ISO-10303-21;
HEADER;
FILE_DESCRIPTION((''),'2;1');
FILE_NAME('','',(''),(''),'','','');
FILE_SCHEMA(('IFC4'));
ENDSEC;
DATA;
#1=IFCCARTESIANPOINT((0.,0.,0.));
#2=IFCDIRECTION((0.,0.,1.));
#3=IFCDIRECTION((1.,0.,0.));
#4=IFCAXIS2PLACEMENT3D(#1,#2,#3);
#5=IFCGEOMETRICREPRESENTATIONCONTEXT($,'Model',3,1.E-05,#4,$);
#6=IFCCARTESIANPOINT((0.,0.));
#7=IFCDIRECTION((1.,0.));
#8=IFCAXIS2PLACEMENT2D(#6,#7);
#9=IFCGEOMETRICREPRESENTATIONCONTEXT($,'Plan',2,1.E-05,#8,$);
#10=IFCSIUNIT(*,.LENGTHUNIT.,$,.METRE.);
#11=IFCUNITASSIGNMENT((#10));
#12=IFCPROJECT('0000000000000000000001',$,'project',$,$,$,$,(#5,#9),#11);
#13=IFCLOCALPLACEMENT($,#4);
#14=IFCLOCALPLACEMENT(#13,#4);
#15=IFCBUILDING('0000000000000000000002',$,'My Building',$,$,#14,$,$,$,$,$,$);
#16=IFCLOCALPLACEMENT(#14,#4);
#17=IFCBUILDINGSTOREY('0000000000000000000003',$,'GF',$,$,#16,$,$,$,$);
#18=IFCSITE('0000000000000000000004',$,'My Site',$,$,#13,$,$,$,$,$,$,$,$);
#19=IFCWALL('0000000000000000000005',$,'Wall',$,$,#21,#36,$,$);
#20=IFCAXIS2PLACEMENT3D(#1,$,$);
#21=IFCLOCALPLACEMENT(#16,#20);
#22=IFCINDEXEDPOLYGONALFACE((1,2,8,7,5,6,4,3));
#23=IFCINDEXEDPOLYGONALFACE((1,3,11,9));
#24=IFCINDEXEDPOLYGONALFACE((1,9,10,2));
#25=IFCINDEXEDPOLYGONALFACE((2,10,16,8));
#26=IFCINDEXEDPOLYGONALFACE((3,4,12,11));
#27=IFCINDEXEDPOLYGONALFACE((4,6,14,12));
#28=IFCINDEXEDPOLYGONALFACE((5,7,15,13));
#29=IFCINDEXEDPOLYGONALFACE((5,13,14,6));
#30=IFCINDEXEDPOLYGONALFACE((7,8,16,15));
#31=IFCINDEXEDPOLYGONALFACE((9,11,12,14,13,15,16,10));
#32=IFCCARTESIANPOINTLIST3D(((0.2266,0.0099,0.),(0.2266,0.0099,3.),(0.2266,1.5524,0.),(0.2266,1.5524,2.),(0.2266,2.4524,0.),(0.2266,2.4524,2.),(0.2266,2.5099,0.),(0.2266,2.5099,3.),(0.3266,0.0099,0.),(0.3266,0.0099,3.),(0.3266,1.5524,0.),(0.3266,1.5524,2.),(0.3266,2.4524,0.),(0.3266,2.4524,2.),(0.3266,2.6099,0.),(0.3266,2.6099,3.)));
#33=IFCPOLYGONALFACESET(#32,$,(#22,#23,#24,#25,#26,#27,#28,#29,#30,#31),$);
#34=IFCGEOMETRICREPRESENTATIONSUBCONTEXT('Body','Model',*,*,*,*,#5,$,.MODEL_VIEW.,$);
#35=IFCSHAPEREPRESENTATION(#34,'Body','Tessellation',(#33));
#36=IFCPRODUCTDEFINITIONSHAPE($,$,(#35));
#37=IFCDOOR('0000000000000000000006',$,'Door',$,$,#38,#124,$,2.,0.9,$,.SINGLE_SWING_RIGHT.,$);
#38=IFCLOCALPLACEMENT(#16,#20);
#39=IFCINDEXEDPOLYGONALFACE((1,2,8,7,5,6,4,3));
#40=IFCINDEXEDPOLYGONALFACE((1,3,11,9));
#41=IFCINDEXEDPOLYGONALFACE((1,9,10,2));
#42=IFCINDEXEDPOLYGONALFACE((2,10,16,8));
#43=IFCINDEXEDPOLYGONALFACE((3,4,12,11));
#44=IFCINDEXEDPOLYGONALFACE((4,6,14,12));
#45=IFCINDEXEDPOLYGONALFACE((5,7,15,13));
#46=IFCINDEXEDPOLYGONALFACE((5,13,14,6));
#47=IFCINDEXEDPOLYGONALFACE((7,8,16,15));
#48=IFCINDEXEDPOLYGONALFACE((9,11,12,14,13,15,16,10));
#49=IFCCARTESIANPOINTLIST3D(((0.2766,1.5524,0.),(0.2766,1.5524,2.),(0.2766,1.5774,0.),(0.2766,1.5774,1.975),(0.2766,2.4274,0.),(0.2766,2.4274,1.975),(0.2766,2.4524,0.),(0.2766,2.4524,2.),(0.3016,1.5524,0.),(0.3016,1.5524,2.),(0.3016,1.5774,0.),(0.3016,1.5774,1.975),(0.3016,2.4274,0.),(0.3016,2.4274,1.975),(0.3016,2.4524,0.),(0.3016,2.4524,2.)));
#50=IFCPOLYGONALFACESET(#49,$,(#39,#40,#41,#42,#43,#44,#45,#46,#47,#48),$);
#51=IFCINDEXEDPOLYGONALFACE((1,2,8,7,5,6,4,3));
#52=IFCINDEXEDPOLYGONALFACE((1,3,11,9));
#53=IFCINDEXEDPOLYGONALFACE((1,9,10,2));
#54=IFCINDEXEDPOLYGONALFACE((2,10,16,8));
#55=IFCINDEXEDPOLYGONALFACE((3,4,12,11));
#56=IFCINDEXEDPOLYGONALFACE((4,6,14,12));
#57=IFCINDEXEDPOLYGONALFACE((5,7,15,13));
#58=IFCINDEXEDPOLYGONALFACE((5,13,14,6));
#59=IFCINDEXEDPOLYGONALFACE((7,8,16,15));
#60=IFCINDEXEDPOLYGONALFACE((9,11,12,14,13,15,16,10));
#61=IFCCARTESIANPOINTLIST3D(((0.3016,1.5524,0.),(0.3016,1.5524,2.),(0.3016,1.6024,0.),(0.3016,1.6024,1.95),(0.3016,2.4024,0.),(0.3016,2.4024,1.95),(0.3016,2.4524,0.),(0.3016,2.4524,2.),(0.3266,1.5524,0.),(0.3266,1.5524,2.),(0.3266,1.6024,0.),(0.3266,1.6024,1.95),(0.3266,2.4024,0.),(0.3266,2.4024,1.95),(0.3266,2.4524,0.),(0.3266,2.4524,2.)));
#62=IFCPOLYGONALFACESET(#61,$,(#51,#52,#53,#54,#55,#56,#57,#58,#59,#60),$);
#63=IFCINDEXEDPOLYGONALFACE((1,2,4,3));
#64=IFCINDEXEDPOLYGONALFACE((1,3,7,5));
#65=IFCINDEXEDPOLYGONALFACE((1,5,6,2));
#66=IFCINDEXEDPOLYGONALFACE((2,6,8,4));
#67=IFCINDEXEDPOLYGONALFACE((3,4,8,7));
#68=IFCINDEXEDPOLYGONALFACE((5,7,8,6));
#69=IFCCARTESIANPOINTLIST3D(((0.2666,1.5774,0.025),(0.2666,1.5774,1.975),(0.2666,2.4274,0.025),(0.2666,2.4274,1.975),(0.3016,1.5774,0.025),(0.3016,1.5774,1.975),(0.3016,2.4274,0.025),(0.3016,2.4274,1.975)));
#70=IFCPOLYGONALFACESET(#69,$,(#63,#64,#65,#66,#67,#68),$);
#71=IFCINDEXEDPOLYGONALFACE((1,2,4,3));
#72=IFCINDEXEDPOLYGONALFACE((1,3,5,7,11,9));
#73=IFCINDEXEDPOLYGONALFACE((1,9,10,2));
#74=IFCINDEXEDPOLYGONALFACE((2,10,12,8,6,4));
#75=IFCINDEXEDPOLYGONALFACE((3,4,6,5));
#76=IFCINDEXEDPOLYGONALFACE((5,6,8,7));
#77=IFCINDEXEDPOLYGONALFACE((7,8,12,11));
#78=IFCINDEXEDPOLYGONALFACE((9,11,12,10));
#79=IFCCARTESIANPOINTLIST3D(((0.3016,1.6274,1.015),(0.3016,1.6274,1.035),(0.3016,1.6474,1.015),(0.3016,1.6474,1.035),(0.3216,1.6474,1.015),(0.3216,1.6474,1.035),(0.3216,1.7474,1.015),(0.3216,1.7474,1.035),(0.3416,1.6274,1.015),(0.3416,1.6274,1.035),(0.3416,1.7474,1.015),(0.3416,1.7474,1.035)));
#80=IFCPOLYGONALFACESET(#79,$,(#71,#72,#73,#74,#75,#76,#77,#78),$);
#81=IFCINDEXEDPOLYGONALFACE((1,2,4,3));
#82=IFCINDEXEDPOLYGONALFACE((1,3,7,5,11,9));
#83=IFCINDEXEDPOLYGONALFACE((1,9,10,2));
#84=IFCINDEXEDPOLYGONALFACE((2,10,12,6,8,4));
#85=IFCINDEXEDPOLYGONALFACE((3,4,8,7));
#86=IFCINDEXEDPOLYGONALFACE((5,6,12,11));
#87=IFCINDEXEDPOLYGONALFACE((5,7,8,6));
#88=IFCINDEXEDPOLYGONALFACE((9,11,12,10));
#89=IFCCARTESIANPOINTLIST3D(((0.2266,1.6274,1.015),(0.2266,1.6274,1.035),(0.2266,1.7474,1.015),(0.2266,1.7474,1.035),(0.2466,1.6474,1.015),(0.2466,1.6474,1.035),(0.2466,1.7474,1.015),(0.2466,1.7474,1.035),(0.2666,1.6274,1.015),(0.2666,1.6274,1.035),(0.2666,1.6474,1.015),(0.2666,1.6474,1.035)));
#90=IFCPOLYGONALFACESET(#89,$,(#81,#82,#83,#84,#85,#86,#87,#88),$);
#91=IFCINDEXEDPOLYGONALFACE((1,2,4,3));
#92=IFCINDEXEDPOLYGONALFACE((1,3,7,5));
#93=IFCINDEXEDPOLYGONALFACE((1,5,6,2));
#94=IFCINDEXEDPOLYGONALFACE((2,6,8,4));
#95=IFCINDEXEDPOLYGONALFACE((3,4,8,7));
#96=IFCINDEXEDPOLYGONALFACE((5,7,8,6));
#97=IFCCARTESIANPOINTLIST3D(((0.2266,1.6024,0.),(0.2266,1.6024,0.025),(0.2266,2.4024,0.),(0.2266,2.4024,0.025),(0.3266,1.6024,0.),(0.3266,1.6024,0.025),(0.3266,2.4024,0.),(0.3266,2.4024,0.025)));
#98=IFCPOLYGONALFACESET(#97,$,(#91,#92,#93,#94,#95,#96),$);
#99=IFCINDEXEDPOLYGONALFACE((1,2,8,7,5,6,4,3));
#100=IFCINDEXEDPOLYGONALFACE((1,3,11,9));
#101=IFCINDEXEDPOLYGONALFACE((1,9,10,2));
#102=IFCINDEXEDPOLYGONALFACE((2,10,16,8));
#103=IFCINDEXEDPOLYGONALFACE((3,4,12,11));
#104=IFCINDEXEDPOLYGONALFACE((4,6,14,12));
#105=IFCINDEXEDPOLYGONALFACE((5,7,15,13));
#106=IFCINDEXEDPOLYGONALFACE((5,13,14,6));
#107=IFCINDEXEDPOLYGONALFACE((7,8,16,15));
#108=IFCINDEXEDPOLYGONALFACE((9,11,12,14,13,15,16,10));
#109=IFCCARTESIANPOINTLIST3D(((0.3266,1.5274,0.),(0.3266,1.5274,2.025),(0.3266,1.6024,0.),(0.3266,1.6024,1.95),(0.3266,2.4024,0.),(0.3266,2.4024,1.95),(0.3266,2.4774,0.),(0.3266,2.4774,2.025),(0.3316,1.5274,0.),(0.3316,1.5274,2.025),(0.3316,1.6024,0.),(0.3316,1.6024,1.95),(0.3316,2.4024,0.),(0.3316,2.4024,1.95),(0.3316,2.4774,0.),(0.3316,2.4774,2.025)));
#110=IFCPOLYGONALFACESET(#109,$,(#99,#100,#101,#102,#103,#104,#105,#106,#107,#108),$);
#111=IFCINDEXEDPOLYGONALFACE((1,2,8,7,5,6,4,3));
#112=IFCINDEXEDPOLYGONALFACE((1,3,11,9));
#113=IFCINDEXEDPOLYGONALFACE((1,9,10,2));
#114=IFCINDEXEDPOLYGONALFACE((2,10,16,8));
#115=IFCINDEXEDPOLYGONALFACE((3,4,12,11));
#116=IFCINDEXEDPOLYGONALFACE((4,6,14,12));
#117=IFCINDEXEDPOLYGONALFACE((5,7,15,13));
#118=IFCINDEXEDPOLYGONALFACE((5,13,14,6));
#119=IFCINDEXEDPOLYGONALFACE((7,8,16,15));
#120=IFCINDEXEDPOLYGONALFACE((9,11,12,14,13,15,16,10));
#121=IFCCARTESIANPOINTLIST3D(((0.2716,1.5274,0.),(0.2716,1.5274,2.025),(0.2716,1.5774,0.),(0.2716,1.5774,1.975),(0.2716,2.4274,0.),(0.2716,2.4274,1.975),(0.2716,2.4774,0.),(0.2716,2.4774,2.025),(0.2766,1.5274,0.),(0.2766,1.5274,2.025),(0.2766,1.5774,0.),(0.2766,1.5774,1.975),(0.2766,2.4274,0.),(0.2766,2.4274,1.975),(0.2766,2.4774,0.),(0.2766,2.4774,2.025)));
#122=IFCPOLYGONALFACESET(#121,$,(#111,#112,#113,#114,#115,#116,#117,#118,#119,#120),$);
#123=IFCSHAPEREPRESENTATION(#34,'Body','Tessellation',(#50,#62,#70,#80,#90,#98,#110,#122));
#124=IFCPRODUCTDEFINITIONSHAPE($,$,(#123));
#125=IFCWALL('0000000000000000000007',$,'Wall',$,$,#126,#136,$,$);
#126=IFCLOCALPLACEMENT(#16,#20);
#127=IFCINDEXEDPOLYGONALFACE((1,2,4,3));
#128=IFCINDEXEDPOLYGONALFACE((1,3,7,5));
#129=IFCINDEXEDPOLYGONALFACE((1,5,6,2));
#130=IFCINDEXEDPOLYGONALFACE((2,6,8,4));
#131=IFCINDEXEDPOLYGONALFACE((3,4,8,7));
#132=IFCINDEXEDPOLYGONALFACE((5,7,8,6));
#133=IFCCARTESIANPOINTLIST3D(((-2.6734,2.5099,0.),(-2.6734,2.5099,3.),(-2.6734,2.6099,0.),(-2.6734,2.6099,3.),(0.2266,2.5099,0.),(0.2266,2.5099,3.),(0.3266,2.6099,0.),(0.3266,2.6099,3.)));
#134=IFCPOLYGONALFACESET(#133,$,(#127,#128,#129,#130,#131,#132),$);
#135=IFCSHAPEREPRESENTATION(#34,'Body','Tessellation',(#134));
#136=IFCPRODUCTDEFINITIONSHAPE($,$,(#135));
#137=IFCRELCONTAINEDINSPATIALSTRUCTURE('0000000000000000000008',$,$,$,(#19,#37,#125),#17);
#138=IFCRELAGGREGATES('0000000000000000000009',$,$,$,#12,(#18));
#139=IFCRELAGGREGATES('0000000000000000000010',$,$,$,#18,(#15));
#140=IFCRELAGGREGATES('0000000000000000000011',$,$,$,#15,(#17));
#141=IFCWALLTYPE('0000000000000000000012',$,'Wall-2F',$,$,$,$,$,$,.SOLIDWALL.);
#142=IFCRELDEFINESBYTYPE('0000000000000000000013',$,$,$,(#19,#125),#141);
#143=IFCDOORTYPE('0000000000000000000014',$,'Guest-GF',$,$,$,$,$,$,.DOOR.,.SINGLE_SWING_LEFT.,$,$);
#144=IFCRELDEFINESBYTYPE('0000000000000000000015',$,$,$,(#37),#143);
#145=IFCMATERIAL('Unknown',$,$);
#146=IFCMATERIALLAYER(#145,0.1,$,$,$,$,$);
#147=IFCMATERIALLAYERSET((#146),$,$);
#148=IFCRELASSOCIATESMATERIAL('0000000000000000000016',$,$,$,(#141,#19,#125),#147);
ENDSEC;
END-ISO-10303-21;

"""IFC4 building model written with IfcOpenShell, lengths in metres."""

from ifc_helpers import new_model, entity, si_unit, frame, origin_with_axes, origin_2d_with_axis, place, context, subcontext, project, spatial, line, indexed_curve, outline, extrude, shape, source, transform, mapped, material, layer, layer_set, layer_usage, type_object, type_shapes, element, fill, save


model = new_model("IFC4")

# Units and contexts
model_context = context("Model", 3, precision=1e-05, world=origin_with_axes())
plan_context = context("Plan", 2, precision=1e-05, world=origin_2d_with_axis())
body_context_1 = subcontext(model_context, "Body", "Model", "MODEL_VIEW")
body_context_2 = subcontext(plan_context, "Body", "Plan", "PLAN_VIEW")
ifc_project = project(units=[si_unit("LENGTHUNIT", "METRE")], contexts=[model_context, plan_context])

# Site, building, storey
site_placement = place(None, origin_with_axes())
site = spatial("IfcSite", under=ifc_project, at=site_placement, Name="My Site")
building_placement = place(site_placement, origin_with_axes())
building = spatial("IfcBuilding", under=site, at=building_placement, Name="My Building")
storey_placement = place(building_placement, origin_with_axes())
storey = spatial("IfcBuildingStorey", under=building, at=storey_placement, Name="GF")

# Shared definitions
ifc_material_1 = material(Name="Unknown")

# Shared definitions
ifc_layer_1 = layer(ifc_material_1, 0.1)
ifc_layer_set_1 = layer_set([ifc_layer_1])
wall_type = type_object("IfcWallType", Name="Wall-2F", PredefinedType="SOLIDWALL", material=ifc_layer_set_1)

# Wall, opening, door
ifc_layer_usage_1 = layer_usage(ifc_layer_set_1, "AXIS2", "POSITIVE", 0.0)
wall_1_placement = place(storey_placement, frame((0.3266, 0.0099, 0.0), z_axis=(0.0, 0.0, 1.0), x_axis=(0.0, 1.0, 0.0)))
wall_1 = element("IfcWall", 1, at=wall_1_placement, inside=storey, type_object=wall_type, material=ifc_layer_usage_1, Name="Wall", context=body_context_1, shape_type="SweptSolid", body=[
    extrude(outline(indexed_curve([(0.0, 0.0), (0.0, 0.1), (2.5, 0.1), (2.6, 0.0)], segments=[line(1, 2, 3, 4, 1)])), origin_with_axes(), (0.0, 0.0, 1.0), 3.0),
])
shared_shape_1 = source(origin_with_axes(), body_context_1, "Body", "SweptSolid", [
    extrude(outline(indexed_curve([(0.0, 0.0), (0.9, 0.0), (0.9, 2.0), (0.0, 2.0)], segments=[line(1, 2, 3, 4, 1)])), frame((0.0, -0.6, 0.0), z_axis=(0.0, -1.0, 0.0), x_axis=(1.0, 0.0, 0.0)), (0.0, 0.0, -1.0), 1.2),
])
opening_1_placement = place(wall_1_placement, frame((1.5425, 0.0, 0.0), z_axis=(0.0, 0.0, 1.0), x_axis=(1.0, 0.0, 0.0)))
opening_1 = element("IfcOpeningElement", 2, at=opening_1_placement, cuts=wall_1, PredefinedType="OPENING", context=body_context_1, shape_type="MappedRepresentation", body=[
    mapped(shared_shape_1, transform((0.0, 0.0, 0.0), x_axis=(1.0, 0.0, 0.0), y_axis=(0.0, 1.0, 0.0), z_axis=(0.0, 0.0, 1.0), scale=1.0)),
])
door_type_1 = type_object("IfcDoorType", Name="Guest-GF", OperationType="SINGLE_SWING_LEFT", PredefinedType="DOOR")
shared_shape_2 = source(origin_with_axes(), body_context_1, "Body", "SweptSolid", [
    extrude(outline(indexed_curve([(0.0, 0.0), (0.0, 2.0), (0.9, 2.0), (0.9, 0.0), (0.875, 0.0), (0.875, 1.975), (0.025, 1.975), (0.025, 0.0)], segments=[line(1, 2, 3, 4, 5, 6, 7, 8, 1)])), frame((0.0, 0.025, 0.0), z_axis=(0.0, -1.0, 0.0), x_axis=(1.0, 0.0, 0.0)), (0.0, 0.0, -1.0), 0.025),
    extrude(outline(indexed_curve([(0.0, 0.0), (0.0, 2.0), (0.9, 2.0), (0.9, 0.0), (0.85, 0.0), (0.85, 1.95), (0.05, 1.95), (0.05, 0.0)], segments=[line(1, 2, 3, 4, 5, 6, 7, 8, 1)])), frame((0.0, 0.0, 0.0), z_axis=(0.0, -1.0, 0.0), x_axis=(1.0, 0.0, 0.0)), (0.0, 0.0, -1.0), 0.025),
    extrude(outline(indexed_curve([(0.0, 0.0), (0.85, 0.0), (0.85, 0.035), (0.0, 0.035)], segments=[line(1, 2, 3, 4, 1)])), frame((0.025, 0.025, 0.025), z_axis=(0.0, 0.0, 1.0), x_axis=(1.0, 0.0, 0.0)), (0.0, 0.0, 1.0), 1.95),
    extrude(outline(indexed_curve([(0.0, 0.0), (0.0, -0.04), (0.12, -0.04), (0.12, -0.02), (0.02, -0.02), (0.02, 0.0)], segments=[line(1, 2, 3, 4, 5, 6, 1)])), frame((0.075, 0.025, 1.015), z_axis=(0.0, 0.0, 1.0), x_axis=(1.0, 0.0, 0.0)), (0.0, 0.0, 1.0), 0.02),
    extrude(outline(indexed_curve([(0.0, 0.0), (0.0, 0.04), (0.12, 0.04), (0.12, 0.02), (0.02, 0.02), (0.02, 0.0)], segments=[line(1, 2, 3, 4, 5, 6, 1)])), frame((0.075, 0.06, 1.015), z_axis=(0.0, 0.0, 1.0), x_axis=(1.0, 0.0, 0.0)), (0.0, 0.0, 1.0), 0.02),
    extrude(outline(indexed_curve([(0.0, 0.0), (0.8, 0.0), (0.8, 0.1), (0.0, 0.1)], segments=[line(1, 2, 3, 4, 1)])), frame((0.05, 0.0, 0.0), z_axis=(0.0, 0.0, 1.0), x_axis=(1.0, 0.0, 0.0)), (0.0, 0.0, 1.0), 0.025),
    extrude(outline(indexed_curve([(0.0, 0.0), (0.0, 2.025), (0.95, 2.025), (0.95, 0.0), (0.875, 0.0), (0.875, 1.95), (0.075, 1.95), (0.075, 0.0)], segments=[line(1, 2, 3, 4, 5, 6, 7, 8, 1)])), frame((-0.025, -0.005, 0.0), z_axis=(0.0, -1.0, 0.0), x_axis=(1.0, 0.0, 0.0)), (0.0, 0.0, -1.0), 0.005),
    extrude(outline(indexed_curve([(0.0, 0.0), (0.0, 2.025), (0.95, 2.025), (0.95, 0.0), (0.9, 0.0), (0.9, 1.975), (0.05, 1.975), (0.05, 0.0)], segments=[line(1, 2, 3, 4, 5, 6, 7, 8, 1)])), frame((-0.025, 0.05, 0.0), z_axis=(0.0, -1.0, 0.0), x_axis=(1.0, 0.0, 0.0)), (0.0, 0.0, -1.0), 0.005),
])
shared_shape_3 = source(origin_with_axes(), body_context_2, "Body", "Curve2D", [
    entity("IfcIndexedPolyCurve", entity("IfcCartesianPointList2D", [[0.0, 0.0], [0.0, 0.05], [0.025, 0.05], [0.025, 0.025], [0.05, 0.025], [0.05, 0.0]]), [entity("IfcLineIndex", [1, 2, 3, 4, 5, 6, 1])]),
    entity("IfcIndexedPolyCurve", entity("IfcCartesianPointList2D", [[0.9, 0.0], [0.9, 0.05], [0.875, 0.05], [0.875, 0.025], [0.85, 0.025], [0.85, 0.0]]), [entity("IfcLineIndex", [1, 2, 3, 4, 5, 6, 1])]),
    entity("IfcTrimmedCurve", entity("IfcEllipse", entity("IfcAxis2Placement2D", entity("IfcCartesianPoint", [0.84, 0.05]), entity("IfcDirection", [1.0, 0.0])), 0.815, 0.85), [entity("IfcCartesianPoint", [0.84, 0.9])], [entity("IfcCartesianPoint", [0.025, 0.05])], True, "CARTESIAN"),
    entity("IfcIndexedPolyCurve", entity("IfcCartesianPointList2D", [[0.875, 0.05], [0.84, 0.05], [0.84, 0.9], [0.875, 0.9]]), [entity("IfcLineIndex", [1, 2, 3, 4, 1])]),
])
type_shapes(door_type_1, [shared_shape_2, shared_shape_3])
door_1_placement = place(opening_1_placement, frame((0.0, 0.0, 0.0), z_axis=(0.0, 0.0, 1.0), x_axis=(1.0, 0.0, 0.0)))
door_1 = element("IfcDoor", 3, at=door_1_placement, inside=storey, type_object=door_type_1, Name="Door", OperationType="SINGLE_SWING_RIGHT", OverallHeight=2.0, OverallWidth=0.9, shapes=[
    shape(body_context_1, "Body", "MappedRepresentation", [mapped(shared_shape_2, transform((0.0, 0.0, 0.0), x_axis=(1.0, 0.0, 0.0), y_axis=(0.0, 1.0, 0.0), z_axis=(0.0, 0.0, 1.0), scale=1.0))]),
    shape(body_context_2, "Body", "MappedRepresentation", [mapped(shared_shape_3, transform((0.0, 0.0, 0.0), x_axis=(1.0, 0.0, 0.0), y_axis=(0.0, 1.0, 0.0), z_axis=(0.0, 0.0, 1.0), scale=1.0))]),
])
fill(opening_1, door_1)

# Wall
ifc_layer_usage_2 = layer_usage(ifc_layer_set_1, "AXIS2", "POSITIVE", 0.0)
wall_2_placement = place(storey_placement, frame((0.3266, 2.6099, 0.0), z_axis=(0.0, 0.0, 1.0), x_axis=(-1.0, 0.0, 0.0)))
element("IfcWall", 4, at=wall_2_placement, inside=storey, type_object=wall_type, material=ifc_layer_usage_2, Name="Wall", context=body_context_1, shape_type="SweptSolid", body=[
    extrude(outline(indexed_curve([(0.0, 0.0), (0.1, 0.1), (3.0, 0.1), (3.0, 0.0)], segments=[line(1, 2, 3, 4, 1)])), origin_with_axes(), (0.0, 0.0, 1.0), 3.0),
])

save(model, "model.ifc")
